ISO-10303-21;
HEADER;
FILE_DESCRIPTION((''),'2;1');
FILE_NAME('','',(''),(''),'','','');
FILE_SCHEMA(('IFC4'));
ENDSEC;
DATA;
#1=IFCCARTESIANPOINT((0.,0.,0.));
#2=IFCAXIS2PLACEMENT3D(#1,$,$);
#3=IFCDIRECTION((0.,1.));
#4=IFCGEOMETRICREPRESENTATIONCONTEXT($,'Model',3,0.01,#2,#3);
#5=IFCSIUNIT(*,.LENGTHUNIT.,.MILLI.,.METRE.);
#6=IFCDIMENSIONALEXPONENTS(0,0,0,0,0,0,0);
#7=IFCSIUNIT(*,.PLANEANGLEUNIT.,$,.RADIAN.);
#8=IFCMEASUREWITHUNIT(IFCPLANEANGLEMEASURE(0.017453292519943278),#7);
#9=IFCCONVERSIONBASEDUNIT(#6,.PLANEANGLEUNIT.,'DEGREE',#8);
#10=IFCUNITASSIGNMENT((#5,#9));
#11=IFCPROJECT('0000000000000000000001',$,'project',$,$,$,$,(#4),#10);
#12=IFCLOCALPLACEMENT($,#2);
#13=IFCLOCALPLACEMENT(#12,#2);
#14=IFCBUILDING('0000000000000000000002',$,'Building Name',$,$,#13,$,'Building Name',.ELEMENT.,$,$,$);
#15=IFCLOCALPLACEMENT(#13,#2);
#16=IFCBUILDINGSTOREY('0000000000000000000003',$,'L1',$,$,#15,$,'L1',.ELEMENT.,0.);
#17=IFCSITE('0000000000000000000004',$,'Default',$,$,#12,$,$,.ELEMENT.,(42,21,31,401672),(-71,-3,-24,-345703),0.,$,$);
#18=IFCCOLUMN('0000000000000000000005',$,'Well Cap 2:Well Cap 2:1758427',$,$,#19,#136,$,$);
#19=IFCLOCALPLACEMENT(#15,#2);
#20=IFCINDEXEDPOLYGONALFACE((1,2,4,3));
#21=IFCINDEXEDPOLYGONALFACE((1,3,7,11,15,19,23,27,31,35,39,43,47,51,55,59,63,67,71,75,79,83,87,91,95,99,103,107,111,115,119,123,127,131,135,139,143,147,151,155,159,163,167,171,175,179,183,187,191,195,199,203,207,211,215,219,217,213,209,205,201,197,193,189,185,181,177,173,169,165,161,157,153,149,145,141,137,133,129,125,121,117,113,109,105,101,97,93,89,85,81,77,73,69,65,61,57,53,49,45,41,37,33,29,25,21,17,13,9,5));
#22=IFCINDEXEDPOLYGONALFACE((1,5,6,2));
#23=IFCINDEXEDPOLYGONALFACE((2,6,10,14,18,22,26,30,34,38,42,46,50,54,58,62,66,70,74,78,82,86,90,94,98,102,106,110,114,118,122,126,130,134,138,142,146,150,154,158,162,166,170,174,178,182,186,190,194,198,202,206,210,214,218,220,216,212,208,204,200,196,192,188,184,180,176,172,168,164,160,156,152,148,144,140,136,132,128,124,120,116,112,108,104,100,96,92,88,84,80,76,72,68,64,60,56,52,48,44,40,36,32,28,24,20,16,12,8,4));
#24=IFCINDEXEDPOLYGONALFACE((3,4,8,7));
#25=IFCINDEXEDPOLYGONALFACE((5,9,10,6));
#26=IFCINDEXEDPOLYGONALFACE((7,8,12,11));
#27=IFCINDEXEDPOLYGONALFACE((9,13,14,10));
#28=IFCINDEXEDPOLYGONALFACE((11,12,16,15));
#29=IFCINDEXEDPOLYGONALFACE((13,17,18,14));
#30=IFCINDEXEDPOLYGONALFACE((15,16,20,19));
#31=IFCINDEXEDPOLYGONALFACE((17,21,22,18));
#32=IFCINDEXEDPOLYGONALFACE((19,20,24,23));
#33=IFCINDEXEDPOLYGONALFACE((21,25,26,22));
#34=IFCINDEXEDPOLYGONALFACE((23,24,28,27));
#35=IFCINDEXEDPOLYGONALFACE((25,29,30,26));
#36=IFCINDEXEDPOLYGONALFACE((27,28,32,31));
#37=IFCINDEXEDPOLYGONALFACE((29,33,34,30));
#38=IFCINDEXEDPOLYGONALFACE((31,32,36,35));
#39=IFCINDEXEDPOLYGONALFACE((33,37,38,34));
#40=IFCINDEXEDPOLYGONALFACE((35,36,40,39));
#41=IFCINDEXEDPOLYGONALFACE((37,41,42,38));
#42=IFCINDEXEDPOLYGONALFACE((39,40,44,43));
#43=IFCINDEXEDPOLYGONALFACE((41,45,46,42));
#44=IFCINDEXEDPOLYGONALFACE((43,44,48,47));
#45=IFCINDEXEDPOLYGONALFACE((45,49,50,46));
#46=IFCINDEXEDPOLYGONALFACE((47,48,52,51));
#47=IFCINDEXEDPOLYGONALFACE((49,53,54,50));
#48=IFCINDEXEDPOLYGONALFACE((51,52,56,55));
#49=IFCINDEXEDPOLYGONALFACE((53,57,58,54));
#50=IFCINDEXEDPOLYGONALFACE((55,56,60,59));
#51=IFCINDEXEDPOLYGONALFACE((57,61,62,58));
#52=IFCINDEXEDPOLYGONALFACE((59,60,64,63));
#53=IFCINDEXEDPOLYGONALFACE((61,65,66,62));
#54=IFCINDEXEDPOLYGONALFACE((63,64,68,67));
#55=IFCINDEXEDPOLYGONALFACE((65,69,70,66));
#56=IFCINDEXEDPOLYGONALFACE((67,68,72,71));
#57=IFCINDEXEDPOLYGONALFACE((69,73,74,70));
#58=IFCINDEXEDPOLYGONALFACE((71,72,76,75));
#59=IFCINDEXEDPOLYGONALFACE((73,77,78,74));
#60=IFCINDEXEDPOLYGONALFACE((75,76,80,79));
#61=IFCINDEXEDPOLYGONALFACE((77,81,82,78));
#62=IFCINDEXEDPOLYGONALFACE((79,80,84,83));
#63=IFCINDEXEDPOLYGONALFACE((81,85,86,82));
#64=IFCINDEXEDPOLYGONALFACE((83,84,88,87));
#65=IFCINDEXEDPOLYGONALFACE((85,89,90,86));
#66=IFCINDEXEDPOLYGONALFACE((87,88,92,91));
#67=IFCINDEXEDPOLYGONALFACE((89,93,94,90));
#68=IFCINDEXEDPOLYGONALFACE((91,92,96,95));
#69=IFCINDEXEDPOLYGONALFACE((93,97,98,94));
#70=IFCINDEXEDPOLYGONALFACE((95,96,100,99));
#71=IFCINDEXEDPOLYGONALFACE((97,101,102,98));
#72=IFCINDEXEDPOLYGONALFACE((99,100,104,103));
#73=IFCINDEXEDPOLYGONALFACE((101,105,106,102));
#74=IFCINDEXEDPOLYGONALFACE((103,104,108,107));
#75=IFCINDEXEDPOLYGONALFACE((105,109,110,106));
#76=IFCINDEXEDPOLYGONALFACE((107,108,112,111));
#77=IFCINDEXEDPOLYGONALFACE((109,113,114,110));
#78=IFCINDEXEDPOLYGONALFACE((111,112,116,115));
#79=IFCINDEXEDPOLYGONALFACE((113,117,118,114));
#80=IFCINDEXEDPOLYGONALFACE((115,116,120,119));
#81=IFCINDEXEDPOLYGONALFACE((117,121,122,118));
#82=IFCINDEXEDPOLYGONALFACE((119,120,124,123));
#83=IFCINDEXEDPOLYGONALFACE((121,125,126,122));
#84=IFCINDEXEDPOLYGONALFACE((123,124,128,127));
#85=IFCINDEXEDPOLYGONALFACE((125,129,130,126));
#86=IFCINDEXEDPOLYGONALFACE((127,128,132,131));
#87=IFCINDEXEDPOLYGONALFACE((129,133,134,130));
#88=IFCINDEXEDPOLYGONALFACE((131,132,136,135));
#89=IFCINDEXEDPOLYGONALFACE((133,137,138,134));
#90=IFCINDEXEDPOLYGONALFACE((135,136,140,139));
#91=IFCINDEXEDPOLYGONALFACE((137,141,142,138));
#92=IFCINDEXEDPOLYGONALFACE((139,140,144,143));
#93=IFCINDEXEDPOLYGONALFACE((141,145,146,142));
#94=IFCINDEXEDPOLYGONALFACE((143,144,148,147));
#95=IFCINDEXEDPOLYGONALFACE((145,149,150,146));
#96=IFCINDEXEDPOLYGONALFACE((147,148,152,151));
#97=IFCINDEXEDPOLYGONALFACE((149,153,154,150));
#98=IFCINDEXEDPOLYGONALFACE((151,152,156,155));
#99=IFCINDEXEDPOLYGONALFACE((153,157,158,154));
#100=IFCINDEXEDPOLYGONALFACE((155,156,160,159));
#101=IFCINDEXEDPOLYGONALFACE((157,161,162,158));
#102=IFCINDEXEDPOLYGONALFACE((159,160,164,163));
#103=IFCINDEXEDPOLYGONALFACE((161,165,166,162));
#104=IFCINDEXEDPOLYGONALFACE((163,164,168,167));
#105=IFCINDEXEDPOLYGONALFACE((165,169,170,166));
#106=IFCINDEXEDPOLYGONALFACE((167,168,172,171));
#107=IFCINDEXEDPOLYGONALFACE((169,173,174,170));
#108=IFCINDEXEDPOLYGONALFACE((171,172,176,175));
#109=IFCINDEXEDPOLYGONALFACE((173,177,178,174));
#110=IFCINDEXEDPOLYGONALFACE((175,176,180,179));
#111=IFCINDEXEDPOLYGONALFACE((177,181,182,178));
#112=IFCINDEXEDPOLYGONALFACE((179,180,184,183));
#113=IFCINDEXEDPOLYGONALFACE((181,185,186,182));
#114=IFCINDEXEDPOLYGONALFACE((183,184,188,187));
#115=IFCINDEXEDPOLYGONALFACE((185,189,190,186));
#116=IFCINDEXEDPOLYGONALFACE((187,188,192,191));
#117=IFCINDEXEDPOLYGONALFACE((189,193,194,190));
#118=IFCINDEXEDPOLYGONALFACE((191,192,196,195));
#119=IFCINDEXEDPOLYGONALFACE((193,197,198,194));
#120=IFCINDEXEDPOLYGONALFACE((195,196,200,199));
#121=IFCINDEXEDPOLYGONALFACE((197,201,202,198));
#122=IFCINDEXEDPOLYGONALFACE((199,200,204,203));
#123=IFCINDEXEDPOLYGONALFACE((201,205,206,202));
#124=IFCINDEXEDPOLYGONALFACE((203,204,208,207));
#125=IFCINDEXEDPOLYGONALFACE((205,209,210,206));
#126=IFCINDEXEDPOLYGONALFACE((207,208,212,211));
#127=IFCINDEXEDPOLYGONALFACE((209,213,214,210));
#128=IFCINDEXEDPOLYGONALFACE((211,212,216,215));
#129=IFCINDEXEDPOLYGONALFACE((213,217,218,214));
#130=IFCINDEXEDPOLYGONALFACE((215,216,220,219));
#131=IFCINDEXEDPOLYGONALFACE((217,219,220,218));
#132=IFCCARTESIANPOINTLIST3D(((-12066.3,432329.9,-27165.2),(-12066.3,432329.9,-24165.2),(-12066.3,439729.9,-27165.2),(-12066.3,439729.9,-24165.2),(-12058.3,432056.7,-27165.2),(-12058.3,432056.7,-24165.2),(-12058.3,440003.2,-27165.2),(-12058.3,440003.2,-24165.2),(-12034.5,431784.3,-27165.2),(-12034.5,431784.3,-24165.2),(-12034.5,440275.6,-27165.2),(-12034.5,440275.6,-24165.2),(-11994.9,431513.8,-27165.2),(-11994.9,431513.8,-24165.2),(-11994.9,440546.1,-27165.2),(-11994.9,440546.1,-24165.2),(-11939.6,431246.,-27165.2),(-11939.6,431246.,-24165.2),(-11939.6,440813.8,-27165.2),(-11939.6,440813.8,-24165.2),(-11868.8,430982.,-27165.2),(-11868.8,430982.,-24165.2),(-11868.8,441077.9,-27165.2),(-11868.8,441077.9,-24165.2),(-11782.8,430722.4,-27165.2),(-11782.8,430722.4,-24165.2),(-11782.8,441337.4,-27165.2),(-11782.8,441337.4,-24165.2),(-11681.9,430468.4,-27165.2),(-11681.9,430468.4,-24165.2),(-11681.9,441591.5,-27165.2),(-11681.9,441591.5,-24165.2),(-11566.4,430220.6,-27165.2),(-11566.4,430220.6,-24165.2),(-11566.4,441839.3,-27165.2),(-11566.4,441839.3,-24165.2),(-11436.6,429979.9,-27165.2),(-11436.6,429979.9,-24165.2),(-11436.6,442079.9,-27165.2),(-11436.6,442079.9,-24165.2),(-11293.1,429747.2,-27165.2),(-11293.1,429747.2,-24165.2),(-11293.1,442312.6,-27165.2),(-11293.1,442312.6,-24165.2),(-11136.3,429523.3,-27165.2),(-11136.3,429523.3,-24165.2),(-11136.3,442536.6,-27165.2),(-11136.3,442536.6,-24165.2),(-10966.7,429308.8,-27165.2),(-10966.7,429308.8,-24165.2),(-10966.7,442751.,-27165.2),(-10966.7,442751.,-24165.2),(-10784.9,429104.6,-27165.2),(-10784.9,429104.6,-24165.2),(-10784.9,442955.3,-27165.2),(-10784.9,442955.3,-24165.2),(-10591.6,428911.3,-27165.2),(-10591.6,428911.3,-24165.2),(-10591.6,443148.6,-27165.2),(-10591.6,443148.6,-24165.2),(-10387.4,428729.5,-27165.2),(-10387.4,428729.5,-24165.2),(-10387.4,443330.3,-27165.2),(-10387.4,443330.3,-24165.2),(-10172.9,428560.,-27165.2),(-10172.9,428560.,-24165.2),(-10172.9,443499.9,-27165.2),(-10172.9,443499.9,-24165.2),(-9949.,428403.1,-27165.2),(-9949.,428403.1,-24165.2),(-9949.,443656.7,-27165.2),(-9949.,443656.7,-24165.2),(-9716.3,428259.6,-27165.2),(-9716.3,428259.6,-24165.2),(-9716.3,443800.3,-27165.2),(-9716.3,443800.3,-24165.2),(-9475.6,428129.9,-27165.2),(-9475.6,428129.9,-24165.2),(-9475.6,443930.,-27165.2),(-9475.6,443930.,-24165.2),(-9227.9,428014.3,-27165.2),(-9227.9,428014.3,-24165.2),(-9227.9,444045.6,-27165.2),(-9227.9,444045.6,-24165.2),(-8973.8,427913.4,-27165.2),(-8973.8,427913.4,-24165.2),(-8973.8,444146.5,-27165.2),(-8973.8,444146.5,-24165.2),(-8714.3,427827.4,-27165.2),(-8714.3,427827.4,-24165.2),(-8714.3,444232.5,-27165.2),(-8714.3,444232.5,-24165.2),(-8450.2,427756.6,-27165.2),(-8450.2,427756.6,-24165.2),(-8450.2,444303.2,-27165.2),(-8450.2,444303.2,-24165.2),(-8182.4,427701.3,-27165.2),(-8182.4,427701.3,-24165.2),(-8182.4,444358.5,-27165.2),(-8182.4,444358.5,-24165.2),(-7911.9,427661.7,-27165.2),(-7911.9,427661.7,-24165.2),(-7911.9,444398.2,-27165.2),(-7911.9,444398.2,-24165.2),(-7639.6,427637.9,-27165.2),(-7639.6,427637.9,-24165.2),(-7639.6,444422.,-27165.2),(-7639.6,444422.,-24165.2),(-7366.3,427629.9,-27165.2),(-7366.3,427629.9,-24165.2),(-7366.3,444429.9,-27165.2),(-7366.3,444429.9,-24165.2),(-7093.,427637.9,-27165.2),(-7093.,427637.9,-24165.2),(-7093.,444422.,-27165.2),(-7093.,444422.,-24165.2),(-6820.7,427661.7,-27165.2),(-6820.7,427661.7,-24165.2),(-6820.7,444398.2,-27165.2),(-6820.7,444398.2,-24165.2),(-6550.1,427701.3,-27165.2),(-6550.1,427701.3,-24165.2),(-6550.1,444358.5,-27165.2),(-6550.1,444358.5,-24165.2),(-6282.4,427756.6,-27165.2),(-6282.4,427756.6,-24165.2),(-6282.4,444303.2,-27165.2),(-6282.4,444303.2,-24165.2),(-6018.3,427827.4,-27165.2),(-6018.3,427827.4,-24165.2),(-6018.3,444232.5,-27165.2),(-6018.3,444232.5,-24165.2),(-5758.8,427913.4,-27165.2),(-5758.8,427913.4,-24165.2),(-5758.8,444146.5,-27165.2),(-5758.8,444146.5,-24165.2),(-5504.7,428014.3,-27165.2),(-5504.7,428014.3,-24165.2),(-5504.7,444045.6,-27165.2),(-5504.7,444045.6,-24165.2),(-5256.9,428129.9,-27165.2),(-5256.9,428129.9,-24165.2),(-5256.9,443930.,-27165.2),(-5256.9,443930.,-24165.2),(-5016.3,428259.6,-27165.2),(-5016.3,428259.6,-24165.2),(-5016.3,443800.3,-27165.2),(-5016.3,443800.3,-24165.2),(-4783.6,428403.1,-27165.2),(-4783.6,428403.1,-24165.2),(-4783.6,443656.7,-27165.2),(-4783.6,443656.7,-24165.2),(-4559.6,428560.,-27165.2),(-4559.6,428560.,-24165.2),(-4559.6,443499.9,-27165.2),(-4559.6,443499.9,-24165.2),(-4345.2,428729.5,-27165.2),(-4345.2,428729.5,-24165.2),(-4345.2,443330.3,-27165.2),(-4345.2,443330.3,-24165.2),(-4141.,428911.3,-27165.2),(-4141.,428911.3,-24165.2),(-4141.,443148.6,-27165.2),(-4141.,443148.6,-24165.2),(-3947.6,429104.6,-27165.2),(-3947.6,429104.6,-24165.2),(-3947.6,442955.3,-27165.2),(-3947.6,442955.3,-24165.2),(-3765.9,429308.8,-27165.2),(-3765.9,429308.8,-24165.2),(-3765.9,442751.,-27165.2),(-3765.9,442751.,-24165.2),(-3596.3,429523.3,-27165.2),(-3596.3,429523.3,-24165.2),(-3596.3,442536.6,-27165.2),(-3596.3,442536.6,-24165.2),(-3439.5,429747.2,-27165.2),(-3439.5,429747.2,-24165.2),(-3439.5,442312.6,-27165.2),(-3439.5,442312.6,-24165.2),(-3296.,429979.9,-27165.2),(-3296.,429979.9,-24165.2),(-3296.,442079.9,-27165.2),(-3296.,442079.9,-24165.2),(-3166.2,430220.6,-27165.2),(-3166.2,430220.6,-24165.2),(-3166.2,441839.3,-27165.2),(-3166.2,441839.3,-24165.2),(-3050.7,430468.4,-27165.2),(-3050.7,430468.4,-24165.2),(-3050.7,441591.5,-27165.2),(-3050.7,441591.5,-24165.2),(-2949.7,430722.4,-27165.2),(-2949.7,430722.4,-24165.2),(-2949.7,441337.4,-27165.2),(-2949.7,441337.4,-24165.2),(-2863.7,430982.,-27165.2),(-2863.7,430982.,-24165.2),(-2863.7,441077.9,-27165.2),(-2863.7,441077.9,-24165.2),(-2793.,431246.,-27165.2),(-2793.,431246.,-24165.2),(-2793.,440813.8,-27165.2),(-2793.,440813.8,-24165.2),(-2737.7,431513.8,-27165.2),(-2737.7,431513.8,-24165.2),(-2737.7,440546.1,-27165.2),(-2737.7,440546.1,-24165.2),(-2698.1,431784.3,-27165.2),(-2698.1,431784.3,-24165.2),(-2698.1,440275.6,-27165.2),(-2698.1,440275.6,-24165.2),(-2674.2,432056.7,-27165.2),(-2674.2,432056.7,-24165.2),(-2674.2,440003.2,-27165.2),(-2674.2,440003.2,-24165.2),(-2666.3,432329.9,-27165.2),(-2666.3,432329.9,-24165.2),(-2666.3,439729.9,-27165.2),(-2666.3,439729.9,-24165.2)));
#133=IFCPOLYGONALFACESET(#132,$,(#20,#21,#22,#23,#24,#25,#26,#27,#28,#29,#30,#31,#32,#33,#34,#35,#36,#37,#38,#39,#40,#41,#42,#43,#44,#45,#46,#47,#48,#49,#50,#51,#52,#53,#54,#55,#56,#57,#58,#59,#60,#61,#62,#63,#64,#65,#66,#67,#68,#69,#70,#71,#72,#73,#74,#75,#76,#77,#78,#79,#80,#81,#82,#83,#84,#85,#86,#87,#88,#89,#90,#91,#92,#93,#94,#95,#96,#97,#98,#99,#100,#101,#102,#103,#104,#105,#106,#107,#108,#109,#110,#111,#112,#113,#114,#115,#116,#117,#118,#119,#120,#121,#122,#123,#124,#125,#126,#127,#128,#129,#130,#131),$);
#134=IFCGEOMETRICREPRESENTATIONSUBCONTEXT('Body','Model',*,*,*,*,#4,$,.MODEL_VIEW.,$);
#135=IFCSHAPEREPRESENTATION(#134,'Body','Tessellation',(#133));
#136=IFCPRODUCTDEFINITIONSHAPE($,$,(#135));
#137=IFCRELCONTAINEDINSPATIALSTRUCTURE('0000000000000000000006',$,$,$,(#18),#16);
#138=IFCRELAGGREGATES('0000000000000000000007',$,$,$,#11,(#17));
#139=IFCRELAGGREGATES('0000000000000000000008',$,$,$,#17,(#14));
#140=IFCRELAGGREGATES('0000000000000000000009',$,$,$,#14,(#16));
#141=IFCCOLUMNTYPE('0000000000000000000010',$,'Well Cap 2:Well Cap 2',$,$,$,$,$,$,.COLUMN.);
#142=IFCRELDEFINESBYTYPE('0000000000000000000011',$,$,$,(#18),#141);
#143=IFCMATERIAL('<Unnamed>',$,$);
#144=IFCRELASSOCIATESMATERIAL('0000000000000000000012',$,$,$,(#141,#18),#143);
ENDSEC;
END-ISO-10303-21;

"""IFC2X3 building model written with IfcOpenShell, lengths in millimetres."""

from ifc_helpers import new_model, entity, si_unit, converted_unit, direction, frame, frame_2d, origin, place, context, subcontext, project, spatial, polyline, circle_curve, parameter, trimmed, segment, composite_curve, outline, extrude, source, transform, mapped, material, type_object, type_shapes, element, save


model = new_model("IFC2X3")

# Units and contexts
model_context = context("Model", 3, precision=0.01, world=origin(), true_north=direction((0.0, 1.0)))
body_context = subcontext(model_context, "Body", "Model", "MODEL_VIEW")
ifc_project = project(units=[si_unit("LENGTHUNIT", "METRE", prefix="MILLI"), converted_unit("PLANEANGLEUNIT", "DEGREE", entity("IfcPlaneAngleMeasure", 0.017453292519943278), si_unit("PLANEANGLEUNIT", "RADIAN"), dimensions=[0, 0, 0, 0, 0, 0, 0])], contexts=[model_context])

# Site, building, storey
site_placement = place(None, origin())
site = spatial("IfcSite", under=ifc_project, at=site_placement, Name="Default", CompositionType="ELEMENT", RefLatitude=(42, 21, 31, 401672), RefLongitude=(-71, -3, -24, -345703), RefElevation=0.0)
building_placement = place(site_placement, origin())
building = spatial("IfcBuilding", under=site, at=building_placement, Name="Building Name", LongName="Building Name", CompositionType="ELEMENT")
storey_placement = place(building_placement, origin())
storey = spatial("IfcBuildingStorey", under=building, at=storey_placement, Name="L1", LongName="L1", CompositionType="ELEMENT", Elevation=0.0)

# Column
ifc_material = material(Name="<Unnamed>")
column_type_1 = type_object("IfcColumnType", Name="Well Cap 2:Well Cap 2", PredefinedType="COLUMN", material=ifc_material)
shared_shape_1 = source(origin(), body_context, "Body", "SweptSolid", [
    extrude(outline(composite_curve([segment(polyline([(-3700.0, -4700.0), (3700.0, -4700.0)]), True, "CONTINUOUS"), segment(trimmed(circle_curve(frame_2d((3700.0, 0.0), x_axis=(0.0, -1.0)), 4700.0), [parameter(0.0)], [parameter(180.0)], True, "PARAMETER"), True, "CONTINUOUS"), segment(polyline([(3700.0, 4700.0), (-3700.0, 4700.0)]), True, "CONTINUOUS"), segment(trimmed(circle_curve(frame_2d((-3700.0, 0.0), x_axis=(0.0, 1.0)), 4700.0), [parameter(0.0)], [parameter(180.0)], True, "PARAMETER"), True, "CONTINUOUS")], self_intersect=False)), frame((8064.3, 0.0, 0.0), z_axis=(0.0, 0.0, 1.0), x_axis=(0.0, -1.0, 0.0)), (0.0, 0.0, 1.0), 3000.0),
])
type_shapes(column_type_1, [shared_shape_1])
column_1_placement = place(storey_placement, frame((-15430.5, 436029.9, -27165.2)))
element("IfcColumn", 1, at=column_1_placement, inside=storey, type_object=column_type_1, material=ifc_material, Name="Well Cap 2:Well Cap 2:1758427", context=body_context, shape_type="MappedRepresentation", body=[
    mapped(shared_shape_1, transform((0.0, 0.0, 0.0), scale=1.0)),
])

save(model, "model.ifc")
